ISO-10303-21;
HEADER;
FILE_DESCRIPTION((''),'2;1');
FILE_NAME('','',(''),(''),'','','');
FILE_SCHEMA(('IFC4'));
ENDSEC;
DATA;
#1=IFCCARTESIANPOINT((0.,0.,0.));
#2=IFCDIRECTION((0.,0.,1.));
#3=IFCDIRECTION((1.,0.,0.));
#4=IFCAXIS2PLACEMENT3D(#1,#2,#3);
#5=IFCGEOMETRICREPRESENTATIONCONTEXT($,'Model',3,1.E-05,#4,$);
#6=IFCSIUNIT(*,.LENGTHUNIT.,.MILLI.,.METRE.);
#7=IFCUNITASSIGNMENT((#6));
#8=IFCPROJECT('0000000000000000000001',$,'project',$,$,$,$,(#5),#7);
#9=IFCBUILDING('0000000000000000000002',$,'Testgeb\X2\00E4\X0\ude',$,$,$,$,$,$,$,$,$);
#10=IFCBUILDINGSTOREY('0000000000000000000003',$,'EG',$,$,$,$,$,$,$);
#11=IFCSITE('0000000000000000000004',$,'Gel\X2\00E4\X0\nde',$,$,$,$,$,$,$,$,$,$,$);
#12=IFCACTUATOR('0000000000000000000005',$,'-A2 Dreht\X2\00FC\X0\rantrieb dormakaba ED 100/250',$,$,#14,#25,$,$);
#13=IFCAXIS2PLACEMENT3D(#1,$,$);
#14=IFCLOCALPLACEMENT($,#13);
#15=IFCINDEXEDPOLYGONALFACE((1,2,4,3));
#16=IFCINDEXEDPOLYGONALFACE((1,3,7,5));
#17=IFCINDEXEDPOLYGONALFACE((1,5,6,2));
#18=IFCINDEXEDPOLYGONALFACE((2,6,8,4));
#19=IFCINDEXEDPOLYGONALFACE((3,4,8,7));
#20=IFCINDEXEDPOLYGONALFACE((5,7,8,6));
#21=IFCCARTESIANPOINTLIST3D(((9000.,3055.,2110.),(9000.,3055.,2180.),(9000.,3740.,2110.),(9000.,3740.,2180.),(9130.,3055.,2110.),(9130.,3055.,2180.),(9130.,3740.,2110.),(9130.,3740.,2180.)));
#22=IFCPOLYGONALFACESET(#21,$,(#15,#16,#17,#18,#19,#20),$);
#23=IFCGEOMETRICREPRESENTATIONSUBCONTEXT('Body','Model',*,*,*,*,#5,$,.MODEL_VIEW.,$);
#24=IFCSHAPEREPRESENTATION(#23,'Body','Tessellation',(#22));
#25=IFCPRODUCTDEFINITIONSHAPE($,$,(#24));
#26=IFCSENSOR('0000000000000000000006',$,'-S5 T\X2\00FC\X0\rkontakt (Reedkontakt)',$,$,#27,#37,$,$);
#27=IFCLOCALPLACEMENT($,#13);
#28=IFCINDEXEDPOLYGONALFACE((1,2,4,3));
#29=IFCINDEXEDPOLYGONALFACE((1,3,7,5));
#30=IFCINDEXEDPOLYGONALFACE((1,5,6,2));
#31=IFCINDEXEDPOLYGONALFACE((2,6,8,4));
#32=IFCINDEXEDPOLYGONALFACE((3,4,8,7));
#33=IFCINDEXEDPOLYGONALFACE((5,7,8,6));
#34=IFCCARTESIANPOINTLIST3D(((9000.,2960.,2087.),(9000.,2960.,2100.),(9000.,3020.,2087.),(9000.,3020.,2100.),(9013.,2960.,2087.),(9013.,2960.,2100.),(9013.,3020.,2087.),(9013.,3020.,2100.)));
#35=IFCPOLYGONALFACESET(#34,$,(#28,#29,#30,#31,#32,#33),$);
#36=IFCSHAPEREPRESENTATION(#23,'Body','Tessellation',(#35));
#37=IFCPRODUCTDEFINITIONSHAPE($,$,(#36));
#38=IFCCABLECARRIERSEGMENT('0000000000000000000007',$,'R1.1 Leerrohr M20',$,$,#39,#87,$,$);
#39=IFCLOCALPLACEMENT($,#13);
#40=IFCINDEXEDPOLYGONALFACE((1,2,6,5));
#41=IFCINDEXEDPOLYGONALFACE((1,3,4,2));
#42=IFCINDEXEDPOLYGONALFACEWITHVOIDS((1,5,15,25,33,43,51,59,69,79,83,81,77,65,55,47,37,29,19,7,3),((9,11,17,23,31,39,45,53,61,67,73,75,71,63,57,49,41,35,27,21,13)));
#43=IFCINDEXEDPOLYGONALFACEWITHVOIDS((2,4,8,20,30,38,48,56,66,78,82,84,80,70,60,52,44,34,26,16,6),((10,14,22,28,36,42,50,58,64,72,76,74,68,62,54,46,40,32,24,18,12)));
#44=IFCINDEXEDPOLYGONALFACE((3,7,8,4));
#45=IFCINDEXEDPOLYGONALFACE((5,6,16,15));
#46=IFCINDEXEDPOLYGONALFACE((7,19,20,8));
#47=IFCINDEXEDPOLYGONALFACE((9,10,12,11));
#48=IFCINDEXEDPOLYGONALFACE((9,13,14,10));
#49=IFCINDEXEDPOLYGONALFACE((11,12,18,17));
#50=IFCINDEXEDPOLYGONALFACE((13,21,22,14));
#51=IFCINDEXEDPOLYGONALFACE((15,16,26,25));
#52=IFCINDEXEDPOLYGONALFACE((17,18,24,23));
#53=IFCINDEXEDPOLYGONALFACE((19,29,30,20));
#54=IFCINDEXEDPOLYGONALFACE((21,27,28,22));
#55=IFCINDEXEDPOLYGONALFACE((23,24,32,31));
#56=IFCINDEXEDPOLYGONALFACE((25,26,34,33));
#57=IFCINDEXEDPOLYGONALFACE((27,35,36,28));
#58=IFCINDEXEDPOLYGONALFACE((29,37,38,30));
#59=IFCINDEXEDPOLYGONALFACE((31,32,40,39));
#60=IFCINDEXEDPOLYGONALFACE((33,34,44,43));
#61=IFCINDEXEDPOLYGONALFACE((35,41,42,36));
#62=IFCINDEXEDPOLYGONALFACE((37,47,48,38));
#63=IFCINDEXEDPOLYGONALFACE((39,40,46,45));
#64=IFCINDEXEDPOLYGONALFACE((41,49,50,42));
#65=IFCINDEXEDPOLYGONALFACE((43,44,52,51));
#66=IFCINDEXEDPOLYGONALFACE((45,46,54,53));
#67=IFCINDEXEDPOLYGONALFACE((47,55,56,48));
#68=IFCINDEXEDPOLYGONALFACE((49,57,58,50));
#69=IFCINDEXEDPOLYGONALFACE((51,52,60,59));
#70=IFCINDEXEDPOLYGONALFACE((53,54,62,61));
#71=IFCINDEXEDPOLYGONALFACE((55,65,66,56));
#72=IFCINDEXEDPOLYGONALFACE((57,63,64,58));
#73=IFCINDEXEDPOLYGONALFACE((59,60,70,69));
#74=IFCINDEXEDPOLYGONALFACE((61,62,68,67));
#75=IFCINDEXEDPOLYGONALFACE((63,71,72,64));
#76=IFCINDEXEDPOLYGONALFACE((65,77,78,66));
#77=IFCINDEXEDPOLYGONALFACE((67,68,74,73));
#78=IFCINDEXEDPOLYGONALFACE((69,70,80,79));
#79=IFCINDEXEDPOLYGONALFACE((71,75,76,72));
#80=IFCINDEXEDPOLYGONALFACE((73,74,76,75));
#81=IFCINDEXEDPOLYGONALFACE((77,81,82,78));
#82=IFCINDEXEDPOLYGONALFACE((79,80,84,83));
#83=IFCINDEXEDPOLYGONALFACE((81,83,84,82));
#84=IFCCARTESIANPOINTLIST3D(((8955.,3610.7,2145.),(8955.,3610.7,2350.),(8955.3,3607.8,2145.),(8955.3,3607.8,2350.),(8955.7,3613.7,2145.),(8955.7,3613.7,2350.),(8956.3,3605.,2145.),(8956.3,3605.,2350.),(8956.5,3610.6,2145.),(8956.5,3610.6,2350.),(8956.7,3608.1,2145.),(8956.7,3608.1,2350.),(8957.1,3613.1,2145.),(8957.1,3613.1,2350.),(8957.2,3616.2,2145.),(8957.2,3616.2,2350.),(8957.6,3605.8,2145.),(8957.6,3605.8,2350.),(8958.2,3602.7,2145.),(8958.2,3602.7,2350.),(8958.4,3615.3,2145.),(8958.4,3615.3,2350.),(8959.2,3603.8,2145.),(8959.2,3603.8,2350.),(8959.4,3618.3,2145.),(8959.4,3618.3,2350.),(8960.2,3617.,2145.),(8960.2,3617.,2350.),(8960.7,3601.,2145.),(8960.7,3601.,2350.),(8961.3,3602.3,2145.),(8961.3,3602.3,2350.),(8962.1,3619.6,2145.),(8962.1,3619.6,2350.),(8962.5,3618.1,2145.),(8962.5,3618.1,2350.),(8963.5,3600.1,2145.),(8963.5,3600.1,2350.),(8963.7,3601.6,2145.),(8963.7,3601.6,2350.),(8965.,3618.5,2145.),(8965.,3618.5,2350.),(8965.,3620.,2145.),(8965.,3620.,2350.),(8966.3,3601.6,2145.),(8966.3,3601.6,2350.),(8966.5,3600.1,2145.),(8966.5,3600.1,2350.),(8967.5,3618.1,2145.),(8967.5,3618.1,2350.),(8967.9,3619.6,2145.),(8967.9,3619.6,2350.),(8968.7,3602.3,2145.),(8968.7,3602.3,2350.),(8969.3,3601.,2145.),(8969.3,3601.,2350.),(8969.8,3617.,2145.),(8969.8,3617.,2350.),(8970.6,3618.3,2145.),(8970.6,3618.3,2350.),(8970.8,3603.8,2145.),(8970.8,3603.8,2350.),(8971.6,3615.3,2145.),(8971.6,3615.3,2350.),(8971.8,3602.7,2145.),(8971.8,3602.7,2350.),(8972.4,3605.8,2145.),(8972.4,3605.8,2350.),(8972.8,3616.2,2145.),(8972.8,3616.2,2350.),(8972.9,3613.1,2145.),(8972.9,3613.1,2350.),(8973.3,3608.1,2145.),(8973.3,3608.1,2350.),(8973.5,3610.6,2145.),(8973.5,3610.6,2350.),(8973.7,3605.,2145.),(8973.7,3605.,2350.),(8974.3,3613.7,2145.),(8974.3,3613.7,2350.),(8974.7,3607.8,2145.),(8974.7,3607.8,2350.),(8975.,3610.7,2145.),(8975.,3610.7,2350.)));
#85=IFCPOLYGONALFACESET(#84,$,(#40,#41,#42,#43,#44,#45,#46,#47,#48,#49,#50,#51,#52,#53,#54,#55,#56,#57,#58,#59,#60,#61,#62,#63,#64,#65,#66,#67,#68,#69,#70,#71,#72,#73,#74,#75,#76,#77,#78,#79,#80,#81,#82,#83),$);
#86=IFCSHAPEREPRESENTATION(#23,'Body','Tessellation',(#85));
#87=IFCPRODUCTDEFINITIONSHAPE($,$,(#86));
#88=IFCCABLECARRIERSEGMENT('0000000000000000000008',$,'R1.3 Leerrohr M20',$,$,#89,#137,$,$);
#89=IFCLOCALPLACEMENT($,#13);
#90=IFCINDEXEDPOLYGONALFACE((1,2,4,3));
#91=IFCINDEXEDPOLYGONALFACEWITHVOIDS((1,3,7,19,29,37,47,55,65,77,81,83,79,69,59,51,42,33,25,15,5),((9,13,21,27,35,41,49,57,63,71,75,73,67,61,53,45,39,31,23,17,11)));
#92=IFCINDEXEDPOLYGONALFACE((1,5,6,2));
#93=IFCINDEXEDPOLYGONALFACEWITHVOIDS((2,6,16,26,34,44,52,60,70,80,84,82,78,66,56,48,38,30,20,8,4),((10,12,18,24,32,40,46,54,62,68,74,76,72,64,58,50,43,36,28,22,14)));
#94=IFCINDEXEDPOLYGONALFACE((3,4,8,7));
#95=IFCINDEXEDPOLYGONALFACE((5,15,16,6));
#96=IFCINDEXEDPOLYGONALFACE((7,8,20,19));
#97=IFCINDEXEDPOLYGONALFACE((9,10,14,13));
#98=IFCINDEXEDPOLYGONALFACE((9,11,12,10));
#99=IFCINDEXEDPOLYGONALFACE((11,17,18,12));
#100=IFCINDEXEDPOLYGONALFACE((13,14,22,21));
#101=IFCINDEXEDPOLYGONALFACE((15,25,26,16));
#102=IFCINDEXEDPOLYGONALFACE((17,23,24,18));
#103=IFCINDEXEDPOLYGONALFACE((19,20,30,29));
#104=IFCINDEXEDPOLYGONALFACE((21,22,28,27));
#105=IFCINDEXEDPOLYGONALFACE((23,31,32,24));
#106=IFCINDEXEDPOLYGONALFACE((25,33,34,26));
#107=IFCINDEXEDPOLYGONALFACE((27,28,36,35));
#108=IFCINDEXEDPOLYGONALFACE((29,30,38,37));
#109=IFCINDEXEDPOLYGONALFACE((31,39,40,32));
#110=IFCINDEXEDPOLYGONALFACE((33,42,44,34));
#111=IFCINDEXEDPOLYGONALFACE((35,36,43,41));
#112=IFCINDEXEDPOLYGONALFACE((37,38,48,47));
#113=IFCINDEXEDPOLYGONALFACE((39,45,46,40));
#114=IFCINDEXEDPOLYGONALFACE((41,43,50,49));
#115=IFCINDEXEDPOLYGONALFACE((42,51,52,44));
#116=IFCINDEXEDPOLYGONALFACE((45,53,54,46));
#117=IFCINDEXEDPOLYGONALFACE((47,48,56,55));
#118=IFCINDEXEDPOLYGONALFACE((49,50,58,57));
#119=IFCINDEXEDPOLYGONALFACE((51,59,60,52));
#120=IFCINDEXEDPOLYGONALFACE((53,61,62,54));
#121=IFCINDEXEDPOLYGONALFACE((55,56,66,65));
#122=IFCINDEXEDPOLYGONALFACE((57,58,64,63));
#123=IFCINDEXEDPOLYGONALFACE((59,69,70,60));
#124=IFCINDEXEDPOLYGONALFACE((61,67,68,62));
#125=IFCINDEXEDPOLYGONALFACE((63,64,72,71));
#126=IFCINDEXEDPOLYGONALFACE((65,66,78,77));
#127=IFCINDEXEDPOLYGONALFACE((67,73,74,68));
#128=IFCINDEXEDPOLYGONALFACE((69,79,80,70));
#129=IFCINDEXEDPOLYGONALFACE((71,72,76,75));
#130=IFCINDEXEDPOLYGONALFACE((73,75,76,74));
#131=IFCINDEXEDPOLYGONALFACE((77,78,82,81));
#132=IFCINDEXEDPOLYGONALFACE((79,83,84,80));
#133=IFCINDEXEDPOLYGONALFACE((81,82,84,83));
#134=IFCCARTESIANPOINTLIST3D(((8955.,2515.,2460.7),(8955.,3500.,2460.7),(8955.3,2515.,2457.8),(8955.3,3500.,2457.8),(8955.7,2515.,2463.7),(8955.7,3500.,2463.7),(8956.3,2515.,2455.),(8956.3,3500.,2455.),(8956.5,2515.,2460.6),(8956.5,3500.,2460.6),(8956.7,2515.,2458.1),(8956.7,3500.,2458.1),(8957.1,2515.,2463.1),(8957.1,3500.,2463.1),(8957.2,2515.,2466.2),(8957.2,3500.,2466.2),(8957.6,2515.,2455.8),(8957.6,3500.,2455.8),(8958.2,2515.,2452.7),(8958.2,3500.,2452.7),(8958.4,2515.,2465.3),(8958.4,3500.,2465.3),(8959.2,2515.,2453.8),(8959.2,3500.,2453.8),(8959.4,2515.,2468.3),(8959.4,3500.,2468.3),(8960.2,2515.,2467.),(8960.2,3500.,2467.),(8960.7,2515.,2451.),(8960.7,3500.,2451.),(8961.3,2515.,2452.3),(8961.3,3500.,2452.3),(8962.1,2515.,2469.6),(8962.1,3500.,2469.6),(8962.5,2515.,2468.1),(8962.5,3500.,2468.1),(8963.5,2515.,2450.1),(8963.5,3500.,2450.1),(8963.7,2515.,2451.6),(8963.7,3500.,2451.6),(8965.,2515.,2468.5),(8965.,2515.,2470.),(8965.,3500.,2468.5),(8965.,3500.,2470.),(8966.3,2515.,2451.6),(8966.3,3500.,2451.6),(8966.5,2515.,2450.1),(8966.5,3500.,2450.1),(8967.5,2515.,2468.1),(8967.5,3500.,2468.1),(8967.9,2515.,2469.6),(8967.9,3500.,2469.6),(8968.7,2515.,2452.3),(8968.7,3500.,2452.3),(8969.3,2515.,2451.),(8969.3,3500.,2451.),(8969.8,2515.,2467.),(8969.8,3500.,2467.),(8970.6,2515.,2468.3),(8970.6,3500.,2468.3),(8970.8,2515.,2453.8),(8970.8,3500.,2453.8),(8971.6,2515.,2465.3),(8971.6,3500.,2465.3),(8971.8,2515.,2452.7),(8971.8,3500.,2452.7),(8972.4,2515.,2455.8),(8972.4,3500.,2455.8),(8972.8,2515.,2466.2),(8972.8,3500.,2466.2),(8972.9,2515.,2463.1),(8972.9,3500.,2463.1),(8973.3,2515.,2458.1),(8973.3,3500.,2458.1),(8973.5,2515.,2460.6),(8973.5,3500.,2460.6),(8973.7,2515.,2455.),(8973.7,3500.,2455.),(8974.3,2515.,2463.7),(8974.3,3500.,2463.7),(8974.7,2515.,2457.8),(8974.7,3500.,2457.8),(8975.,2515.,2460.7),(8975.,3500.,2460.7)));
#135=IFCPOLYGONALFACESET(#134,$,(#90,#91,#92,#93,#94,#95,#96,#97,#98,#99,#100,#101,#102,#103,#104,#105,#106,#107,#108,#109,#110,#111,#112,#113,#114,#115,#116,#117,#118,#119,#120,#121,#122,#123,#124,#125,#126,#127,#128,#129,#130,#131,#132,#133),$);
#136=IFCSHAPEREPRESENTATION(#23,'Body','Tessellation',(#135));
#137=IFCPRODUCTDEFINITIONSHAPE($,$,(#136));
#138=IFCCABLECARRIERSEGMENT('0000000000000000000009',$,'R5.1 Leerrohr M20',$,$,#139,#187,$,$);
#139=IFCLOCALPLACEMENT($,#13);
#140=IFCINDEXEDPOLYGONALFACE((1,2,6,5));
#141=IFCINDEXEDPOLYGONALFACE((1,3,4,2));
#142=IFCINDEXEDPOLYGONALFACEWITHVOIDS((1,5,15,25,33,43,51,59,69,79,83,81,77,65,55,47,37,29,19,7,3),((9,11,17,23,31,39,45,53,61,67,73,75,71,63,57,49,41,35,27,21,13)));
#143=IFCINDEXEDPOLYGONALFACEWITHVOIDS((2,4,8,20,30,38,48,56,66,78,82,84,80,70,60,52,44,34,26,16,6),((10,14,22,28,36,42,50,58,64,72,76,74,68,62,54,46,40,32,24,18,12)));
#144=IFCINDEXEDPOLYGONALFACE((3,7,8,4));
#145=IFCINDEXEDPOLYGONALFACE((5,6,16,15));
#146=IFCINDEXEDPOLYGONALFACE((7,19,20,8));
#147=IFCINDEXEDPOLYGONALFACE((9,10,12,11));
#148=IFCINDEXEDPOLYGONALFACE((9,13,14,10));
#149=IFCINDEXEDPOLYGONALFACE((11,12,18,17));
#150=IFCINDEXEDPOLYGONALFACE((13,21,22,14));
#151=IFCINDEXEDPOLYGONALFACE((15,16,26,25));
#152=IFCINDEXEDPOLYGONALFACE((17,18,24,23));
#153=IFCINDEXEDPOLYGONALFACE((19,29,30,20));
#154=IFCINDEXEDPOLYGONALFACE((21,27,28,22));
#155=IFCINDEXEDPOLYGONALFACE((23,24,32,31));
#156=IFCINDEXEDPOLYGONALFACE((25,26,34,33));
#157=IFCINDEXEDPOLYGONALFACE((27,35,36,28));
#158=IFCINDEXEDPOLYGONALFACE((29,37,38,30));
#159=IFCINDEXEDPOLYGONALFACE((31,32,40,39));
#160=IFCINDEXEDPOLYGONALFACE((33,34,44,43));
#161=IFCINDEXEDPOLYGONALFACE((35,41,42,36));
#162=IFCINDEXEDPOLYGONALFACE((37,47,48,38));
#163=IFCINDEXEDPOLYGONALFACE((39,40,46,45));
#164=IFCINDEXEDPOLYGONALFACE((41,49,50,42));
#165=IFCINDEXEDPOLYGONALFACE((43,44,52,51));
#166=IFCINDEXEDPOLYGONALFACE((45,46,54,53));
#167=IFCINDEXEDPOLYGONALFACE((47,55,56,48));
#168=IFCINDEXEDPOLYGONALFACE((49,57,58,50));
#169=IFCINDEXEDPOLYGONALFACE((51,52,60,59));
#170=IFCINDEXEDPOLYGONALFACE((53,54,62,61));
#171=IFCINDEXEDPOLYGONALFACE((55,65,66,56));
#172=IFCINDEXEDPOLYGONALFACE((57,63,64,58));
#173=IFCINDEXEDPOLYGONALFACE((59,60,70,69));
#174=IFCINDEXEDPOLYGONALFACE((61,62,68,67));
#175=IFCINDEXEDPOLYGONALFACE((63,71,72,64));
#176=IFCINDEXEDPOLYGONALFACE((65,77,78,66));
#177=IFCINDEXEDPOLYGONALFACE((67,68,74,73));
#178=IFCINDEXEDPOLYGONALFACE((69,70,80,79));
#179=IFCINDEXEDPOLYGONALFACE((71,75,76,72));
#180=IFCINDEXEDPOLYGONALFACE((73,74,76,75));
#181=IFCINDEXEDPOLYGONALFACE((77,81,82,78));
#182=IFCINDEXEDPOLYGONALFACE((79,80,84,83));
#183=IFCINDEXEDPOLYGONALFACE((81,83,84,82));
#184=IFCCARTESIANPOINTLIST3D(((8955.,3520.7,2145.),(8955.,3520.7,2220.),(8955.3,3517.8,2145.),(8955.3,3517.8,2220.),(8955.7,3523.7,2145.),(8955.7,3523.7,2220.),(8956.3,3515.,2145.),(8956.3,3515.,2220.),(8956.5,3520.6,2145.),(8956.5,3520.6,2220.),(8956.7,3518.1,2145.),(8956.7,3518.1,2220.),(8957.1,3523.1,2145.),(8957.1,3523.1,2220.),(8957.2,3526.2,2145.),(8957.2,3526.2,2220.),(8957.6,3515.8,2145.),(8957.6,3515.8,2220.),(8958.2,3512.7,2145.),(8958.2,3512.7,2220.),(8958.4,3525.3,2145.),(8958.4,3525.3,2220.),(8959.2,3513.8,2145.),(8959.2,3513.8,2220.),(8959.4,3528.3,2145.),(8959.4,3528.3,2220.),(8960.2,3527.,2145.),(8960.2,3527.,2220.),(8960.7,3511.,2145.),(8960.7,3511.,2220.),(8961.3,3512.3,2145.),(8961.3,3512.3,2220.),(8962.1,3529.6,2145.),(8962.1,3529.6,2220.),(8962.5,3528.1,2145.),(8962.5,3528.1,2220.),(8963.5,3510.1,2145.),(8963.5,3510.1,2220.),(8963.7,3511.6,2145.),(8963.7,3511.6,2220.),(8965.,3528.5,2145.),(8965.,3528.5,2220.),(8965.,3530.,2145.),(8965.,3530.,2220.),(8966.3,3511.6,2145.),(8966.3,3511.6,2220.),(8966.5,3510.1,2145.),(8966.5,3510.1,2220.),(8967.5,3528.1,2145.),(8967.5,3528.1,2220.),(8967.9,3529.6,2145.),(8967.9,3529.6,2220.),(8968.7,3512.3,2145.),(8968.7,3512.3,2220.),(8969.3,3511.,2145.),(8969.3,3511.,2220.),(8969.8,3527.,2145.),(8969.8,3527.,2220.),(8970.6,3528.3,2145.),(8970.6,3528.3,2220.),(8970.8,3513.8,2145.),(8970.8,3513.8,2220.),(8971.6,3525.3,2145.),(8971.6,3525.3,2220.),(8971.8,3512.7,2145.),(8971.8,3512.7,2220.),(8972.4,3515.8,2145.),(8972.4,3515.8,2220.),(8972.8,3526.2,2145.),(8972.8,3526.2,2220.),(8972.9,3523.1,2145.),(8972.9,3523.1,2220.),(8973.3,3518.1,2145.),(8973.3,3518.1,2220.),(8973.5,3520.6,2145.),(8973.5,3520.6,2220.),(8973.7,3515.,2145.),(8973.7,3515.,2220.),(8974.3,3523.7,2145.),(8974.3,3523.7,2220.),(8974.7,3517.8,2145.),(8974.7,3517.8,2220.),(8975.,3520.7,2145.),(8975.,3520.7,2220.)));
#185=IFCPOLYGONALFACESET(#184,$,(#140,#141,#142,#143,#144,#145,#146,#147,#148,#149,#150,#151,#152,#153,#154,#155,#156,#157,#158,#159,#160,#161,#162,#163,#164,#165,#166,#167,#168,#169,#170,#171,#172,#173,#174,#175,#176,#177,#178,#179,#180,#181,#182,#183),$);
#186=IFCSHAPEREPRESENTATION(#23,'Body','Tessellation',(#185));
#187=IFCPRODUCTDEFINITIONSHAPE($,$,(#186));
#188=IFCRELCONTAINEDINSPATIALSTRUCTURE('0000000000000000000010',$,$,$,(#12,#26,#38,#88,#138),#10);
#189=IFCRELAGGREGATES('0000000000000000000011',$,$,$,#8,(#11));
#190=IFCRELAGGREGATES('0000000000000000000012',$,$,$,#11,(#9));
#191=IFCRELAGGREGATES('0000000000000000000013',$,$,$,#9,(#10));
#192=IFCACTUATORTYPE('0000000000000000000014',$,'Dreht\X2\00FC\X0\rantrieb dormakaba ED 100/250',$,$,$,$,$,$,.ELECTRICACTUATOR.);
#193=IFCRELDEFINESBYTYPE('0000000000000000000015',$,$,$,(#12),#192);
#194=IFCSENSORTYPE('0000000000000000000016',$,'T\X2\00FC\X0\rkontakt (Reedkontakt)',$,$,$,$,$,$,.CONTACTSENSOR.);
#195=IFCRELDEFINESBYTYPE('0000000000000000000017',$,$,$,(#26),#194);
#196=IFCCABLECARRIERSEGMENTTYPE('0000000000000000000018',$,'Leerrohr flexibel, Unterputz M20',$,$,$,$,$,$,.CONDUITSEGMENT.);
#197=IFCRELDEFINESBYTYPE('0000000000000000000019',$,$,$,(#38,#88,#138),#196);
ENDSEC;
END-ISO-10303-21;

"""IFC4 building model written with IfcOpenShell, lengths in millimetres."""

from ifc_helpers import new_model, si_unit, frame, frame_2d, origin_with_axes, place, context, subcontext, project, spatial, rectangle, hollow_circle, extrude, type_object, element, save


model = new_model("IFC4")

# Units and contexts
model_context = context("Model", 3, precision=1e-05, world=origin_with_axes())
body_context = subcontext(model_context, "Body", "Model", "MODEL_VIEW")
ifc_project = project(units=[si_unit("LENGTHUNIT", "METRE", prefix="MILLI")], contexts=[model_context])

# Site, building, storey
site = spatial("IfcSite", under=ifc_project, Name="Gelände")
building = spatial("IfcBuilding", under=site, Name="Testgebäude")
storey = spatial("IfcBuildingStorey", under=building, Name="EG")

# Actuator
actuator_type = type_object("IfcActuatorType", Name="Drehtürantrieb dormakaba ED 100/250", PredefinedType="ELECTRICACTUATOR")
actuator_placement = place(None, frame((9130.0, 3055.0, 2110.0), z_axis=(0.0, 0.0, 1.0), x_axis=(0.0, 1.0, 0.0)))
element("IfcActuator", 1, at=actuator_placement, inside=storey, type_object=actuator_type, Name="-A2 Drehtürantrieb dormakaba ED 100/250", context=body_context, shape_type="SweptSolid", body=[
    extrude(rectangle(XDim=685.0, YDim=130.0, at=frame_2d((342.5, 65.0))), None, (0.0, 0.0, 1.0), 70.0),
])

# Sensor
sensor_type = type_object("IfcSensorType", Name="Türkontakt (Reedkontakt)", PredefinedType="CONTACTSENSOR")
sensor_placement = place(None, frame((9013.0, 2960.0, 2087.0), z_axis=(0.0, 0.0, 1.0), x_axis=(0.0, 1.0, 0.0)))
element("IfcSensor", 2, at=sensor_placement, inside=storey, type_object=sensor_type, Name="-S5 Türkontakt (Reedkontakt)", context=body_context, shape_type="SweptSolid", body=[
    extrude(rectangle(XDim=60.0, YDim=13.0, at=frame_2d((30.0, 6.5))), None, (0.0, 0.0, 1.0), 13.0),
])

# Cable carrier segments
cable_carrier_segment_type_1 = type_object("IfcCableCarrierSegmentType", Name="Leerrohr flexibel, Unterputz M20", PredefinedType="CONDUITSEGMENT")
cable_carrier_segment_1_placement = place(None, frame((8965.0, 3610.0, 2145.0), z_axis=(0.0, 0.0, 1.0), x_axis=(0.0, 1.0, 0.0)))
element("IfcCableCarrierSegment", 3, at=cable_carrier_segment_1_placement, inside=storey, type_object=cable_carrier_segment_type_1, Name="R1.1 Leerrohr M20", context=body_context, shape_type="SweptSolid", body=[
    extrude(hollow_circle(Radius=10.0, WallThickness=1.5), None, (0.0, 0.0, 1.0), 205.0),
])
cable_carrier_segment_2_placement = place(None, frame((8965.0, 3500.0, 2460.0), z_axis=(0.0, -1.0, 0.0), x_axis=(0.0, 0.0, 1.0)))
element("IfcCableCarrierSegment", 4, at=cable_carrier_segment_2_placement, inside=storey, type_object=cable_carrier_segment_type_1, Name="R1.3 Leerrohr M20", context=body_context, shape_type="SweptSolid", body=[
    extrude(hollow_circle(Radius=10.0, WallThickness=1.5), None, (0.0, 0.0, 1.0), 985.0),
])
cable_carrier_segment_3_placement = place(None, frame((8965.0, 3520.0, 2145.0), z_axis=(0.0, 0.0, 1.0), x_axis=(0.0, 1.0, 0.0)))
element("IfcCableCarrierSegment", 5, at=cable_carrier_segment_3_placement, inside=storey, type_object=cable_carrier_segment_type_1, Name="R5.1 Leerrohr M20", context=body_context, shape_type="SweptSolid", body=[
    extrude(hollow_circle(Radius=10.0, WallThickness=1.5), None, (0.0, 0.0, 1.0), 75.0),
])

save(model, "model.ifc")
